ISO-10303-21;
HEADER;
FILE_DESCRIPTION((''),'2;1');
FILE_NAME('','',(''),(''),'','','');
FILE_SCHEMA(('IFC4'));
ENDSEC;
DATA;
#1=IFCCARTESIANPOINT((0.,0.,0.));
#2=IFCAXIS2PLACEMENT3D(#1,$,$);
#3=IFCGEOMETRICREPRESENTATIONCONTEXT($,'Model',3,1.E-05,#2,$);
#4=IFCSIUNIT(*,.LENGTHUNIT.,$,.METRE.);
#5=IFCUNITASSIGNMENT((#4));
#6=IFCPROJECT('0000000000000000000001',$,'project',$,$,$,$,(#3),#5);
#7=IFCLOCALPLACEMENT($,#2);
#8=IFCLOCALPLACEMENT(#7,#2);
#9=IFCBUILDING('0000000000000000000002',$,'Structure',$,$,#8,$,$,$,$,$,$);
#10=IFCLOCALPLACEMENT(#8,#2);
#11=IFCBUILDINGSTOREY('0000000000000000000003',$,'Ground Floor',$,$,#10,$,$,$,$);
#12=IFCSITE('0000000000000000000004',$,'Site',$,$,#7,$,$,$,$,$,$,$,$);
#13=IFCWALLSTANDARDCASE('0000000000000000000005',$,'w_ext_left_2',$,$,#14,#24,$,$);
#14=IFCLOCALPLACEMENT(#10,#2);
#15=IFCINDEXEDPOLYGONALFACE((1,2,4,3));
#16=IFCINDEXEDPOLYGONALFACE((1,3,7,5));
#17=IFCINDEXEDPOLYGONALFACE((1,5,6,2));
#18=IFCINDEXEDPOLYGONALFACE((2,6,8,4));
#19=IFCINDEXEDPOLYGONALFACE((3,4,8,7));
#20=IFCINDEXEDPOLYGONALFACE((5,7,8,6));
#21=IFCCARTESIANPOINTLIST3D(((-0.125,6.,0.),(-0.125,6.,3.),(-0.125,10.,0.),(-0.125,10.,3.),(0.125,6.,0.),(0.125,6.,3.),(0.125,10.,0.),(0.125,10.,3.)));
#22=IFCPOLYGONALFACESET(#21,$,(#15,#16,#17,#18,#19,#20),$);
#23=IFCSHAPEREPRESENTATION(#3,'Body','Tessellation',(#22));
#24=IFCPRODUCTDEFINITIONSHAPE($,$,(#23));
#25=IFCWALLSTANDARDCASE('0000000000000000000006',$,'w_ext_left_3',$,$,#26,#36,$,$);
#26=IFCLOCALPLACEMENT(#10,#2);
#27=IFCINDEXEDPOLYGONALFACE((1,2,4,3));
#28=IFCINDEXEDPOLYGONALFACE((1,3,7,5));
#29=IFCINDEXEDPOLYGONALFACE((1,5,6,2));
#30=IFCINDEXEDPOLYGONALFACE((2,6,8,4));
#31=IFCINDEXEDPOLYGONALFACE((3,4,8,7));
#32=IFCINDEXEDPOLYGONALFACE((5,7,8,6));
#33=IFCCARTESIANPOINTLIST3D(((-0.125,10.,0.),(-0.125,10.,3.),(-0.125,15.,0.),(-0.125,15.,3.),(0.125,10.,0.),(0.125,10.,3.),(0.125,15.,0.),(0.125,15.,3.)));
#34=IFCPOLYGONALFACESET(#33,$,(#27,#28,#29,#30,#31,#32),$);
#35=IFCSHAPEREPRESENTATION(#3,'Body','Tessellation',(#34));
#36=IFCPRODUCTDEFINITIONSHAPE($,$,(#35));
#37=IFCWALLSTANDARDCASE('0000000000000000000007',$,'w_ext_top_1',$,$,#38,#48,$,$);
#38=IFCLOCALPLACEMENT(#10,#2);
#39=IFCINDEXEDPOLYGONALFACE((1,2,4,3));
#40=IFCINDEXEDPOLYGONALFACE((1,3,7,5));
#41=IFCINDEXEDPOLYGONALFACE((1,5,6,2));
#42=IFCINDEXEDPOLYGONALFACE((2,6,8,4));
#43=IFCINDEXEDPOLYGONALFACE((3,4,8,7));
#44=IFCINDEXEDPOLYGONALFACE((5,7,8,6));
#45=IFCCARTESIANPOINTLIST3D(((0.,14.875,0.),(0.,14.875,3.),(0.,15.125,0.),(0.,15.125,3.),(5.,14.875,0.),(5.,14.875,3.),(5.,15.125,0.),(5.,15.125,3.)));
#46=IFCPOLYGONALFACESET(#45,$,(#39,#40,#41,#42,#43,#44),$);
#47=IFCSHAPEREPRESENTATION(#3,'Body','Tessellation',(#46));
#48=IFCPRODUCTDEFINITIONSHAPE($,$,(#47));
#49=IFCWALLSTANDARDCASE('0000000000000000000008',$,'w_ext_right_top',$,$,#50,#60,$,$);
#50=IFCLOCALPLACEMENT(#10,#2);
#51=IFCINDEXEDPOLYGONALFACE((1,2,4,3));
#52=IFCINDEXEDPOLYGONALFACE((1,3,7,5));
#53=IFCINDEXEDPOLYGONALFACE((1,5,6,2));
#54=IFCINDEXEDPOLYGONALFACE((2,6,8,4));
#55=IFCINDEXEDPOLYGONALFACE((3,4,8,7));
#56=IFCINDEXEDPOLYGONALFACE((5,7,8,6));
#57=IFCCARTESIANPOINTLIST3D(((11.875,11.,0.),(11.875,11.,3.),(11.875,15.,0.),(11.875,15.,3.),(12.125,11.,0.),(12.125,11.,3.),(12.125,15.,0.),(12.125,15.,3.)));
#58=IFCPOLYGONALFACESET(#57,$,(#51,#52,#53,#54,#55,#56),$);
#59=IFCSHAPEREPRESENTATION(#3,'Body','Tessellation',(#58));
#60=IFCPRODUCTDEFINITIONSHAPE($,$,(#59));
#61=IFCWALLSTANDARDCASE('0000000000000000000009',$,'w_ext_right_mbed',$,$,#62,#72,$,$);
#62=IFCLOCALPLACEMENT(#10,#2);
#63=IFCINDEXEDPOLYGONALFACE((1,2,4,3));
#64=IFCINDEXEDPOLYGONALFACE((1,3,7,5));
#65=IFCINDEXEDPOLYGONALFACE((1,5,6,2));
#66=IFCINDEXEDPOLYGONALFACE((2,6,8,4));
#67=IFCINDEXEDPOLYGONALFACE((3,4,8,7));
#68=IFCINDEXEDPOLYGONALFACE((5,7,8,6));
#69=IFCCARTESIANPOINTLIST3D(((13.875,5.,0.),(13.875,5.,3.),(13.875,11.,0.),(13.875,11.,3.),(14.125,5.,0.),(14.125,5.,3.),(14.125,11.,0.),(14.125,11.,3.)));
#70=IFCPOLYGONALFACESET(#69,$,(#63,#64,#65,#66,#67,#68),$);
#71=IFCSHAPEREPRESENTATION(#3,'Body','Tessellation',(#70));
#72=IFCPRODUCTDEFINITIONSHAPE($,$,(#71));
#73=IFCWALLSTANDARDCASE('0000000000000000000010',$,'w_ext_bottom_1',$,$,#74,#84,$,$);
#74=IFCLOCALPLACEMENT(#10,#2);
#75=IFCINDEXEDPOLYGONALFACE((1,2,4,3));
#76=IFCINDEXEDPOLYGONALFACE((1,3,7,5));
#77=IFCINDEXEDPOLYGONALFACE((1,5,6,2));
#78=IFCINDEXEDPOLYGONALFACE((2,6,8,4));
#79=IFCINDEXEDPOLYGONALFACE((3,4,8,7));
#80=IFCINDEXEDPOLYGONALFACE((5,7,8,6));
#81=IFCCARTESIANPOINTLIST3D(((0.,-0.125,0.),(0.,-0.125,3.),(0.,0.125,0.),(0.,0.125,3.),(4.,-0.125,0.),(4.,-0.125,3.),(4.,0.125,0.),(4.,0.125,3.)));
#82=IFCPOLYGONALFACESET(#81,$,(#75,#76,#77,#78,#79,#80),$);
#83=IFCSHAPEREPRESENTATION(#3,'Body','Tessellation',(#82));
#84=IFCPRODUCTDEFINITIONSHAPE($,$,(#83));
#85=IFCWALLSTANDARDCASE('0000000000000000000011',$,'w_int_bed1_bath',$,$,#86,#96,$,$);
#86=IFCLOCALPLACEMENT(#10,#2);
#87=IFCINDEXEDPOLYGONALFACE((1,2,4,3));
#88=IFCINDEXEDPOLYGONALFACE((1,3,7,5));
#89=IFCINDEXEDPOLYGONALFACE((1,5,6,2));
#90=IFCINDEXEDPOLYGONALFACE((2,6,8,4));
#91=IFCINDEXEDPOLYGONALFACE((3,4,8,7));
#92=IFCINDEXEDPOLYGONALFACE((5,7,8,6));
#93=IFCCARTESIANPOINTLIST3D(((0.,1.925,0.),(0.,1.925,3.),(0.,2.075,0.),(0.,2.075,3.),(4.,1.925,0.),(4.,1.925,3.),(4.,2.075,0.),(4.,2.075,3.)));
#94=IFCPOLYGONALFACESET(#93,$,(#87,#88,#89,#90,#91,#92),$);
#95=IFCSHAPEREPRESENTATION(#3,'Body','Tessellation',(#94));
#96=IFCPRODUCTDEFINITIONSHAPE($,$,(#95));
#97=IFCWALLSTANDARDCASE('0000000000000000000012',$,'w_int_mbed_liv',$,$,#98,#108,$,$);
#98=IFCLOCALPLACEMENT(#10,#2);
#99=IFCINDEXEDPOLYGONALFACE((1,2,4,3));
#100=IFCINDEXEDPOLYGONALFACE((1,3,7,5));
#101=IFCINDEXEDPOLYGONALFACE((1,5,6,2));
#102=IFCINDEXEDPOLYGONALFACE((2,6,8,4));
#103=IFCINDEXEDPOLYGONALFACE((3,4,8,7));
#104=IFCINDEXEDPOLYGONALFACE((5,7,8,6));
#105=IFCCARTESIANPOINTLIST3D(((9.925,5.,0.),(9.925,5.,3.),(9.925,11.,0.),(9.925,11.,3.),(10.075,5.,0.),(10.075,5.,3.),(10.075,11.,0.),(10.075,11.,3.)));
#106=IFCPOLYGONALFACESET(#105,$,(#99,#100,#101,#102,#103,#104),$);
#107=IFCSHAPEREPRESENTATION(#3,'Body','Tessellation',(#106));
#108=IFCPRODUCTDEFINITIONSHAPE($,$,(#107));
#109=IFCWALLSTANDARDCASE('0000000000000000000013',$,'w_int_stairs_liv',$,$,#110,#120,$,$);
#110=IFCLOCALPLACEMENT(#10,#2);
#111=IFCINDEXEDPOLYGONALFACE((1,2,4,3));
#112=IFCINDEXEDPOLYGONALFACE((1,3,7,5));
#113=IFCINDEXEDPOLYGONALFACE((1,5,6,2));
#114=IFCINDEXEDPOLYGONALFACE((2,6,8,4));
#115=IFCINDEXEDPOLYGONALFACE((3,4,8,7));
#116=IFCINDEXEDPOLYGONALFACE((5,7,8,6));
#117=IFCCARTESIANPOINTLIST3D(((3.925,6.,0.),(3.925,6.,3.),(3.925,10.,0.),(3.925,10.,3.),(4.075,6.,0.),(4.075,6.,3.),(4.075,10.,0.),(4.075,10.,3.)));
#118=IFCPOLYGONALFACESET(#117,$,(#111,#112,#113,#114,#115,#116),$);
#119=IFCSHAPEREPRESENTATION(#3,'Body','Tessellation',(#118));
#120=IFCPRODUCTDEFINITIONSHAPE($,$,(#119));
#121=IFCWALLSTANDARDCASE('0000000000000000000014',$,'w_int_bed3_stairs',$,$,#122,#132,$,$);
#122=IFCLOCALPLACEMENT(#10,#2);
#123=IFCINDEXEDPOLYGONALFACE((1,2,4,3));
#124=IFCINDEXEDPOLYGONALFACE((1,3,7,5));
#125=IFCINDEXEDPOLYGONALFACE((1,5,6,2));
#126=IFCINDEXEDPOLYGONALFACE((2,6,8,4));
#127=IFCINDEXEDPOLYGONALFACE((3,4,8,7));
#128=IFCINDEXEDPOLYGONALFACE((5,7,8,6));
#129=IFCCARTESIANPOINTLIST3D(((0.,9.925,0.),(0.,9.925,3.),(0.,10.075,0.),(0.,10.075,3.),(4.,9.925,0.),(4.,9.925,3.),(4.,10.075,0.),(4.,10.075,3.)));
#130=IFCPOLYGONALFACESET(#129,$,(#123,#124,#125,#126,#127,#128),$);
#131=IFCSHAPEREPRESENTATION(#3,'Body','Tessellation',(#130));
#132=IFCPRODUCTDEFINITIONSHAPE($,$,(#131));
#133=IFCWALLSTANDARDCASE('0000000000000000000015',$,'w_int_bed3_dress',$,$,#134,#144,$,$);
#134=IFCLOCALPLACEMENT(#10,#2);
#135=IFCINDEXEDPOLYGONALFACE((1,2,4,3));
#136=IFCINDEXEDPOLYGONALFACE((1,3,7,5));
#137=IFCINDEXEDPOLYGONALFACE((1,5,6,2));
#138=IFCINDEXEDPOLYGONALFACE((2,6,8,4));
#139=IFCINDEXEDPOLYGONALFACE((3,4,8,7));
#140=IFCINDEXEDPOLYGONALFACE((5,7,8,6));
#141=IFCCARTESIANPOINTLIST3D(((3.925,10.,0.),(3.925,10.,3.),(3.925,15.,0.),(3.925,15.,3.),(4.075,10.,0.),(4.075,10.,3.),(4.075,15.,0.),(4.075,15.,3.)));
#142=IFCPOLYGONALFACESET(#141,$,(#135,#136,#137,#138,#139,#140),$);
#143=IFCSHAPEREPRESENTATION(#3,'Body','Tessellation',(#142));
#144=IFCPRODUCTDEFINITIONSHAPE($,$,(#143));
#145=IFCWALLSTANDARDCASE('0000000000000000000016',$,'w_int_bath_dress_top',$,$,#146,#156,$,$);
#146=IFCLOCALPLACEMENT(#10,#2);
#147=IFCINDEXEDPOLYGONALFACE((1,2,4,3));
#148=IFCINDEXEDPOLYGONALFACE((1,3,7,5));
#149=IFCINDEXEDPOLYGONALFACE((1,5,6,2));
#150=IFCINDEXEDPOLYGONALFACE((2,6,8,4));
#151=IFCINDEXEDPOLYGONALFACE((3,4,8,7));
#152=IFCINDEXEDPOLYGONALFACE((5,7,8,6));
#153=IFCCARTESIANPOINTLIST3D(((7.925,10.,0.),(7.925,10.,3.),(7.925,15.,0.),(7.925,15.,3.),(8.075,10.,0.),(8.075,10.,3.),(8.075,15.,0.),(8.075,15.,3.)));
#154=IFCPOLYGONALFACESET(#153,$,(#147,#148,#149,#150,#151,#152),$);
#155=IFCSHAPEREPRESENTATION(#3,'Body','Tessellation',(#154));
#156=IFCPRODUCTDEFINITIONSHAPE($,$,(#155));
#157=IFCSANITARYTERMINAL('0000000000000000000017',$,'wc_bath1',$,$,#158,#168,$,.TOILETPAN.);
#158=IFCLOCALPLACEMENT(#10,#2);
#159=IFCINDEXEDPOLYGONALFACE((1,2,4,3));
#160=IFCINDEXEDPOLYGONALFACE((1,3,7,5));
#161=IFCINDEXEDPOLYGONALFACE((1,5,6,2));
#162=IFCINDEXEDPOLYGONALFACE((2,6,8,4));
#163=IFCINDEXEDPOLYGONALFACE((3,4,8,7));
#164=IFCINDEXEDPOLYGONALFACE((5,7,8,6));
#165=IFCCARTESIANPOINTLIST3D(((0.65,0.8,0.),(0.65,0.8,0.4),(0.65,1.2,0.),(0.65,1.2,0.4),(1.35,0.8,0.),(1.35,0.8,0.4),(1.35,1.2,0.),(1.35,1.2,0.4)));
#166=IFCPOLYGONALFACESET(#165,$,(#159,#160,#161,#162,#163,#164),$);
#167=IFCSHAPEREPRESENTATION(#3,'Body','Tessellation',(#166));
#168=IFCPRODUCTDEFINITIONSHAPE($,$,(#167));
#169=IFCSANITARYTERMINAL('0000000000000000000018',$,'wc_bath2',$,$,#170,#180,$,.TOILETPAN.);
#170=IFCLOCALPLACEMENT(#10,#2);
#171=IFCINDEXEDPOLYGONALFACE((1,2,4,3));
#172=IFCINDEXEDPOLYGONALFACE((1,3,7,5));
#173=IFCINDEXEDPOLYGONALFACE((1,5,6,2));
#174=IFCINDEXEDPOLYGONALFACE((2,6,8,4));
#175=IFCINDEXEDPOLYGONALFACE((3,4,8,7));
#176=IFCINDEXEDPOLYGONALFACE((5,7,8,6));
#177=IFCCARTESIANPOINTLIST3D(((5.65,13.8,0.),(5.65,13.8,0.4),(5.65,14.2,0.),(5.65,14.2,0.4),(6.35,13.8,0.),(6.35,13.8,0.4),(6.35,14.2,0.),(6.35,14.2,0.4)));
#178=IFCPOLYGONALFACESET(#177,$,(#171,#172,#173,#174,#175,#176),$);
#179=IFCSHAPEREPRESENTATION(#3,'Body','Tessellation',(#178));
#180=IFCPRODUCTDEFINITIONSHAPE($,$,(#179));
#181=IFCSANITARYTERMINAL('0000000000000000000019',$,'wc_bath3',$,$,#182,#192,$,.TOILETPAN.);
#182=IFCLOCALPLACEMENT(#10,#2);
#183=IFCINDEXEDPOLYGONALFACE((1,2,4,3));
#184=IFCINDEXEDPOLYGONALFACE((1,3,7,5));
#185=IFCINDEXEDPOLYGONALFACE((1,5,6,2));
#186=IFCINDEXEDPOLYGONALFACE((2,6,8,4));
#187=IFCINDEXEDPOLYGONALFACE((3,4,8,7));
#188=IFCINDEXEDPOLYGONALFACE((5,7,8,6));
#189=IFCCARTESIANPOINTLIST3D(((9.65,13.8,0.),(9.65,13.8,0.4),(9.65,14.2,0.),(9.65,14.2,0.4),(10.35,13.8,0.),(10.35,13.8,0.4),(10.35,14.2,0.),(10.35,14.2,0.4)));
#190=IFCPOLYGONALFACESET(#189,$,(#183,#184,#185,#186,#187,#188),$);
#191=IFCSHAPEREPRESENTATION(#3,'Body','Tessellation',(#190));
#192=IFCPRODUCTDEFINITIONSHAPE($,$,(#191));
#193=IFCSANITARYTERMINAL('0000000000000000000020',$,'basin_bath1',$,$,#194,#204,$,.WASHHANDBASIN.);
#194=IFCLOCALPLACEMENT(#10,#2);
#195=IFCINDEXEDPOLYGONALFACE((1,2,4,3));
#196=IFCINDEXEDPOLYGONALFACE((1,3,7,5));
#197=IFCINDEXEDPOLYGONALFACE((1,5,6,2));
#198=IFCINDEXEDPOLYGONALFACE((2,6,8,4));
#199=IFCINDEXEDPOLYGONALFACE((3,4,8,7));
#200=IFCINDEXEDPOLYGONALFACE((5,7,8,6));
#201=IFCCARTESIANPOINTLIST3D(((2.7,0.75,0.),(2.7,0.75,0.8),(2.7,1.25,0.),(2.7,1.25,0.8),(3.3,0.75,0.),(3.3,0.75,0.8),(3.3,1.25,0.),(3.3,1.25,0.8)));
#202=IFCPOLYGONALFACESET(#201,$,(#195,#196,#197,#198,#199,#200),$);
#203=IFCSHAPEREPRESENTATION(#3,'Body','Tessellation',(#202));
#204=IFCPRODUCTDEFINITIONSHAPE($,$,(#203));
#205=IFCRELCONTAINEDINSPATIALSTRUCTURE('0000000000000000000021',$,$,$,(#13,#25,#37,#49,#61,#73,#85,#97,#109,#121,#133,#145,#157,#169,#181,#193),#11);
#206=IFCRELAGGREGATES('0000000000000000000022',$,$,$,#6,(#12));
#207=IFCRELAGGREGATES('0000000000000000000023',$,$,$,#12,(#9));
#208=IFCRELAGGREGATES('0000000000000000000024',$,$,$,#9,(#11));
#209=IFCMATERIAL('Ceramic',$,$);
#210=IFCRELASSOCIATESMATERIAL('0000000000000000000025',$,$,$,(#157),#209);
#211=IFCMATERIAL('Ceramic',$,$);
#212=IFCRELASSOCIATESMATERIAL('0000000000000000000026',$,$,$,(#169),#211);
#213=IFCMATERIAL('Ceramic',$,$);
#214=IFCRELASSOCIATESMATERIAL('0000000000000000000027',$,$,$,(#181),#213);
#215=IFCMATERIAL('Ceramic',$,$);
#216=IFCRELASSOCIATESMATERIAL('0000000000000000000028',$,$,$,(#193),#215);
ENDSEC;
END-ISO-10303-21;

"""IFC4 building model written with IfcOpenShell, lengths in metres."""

from ifc_helpers import new_model, si_unit, frame, origin, place, context, project, spatial, polyline, outline, extrude, material, element, save


model = new_model("IFC4")

# Units and contexts
model_context = context("Model", 3, precision=1e-05, world=origin())
ifc_project = project(units=[si_unit("LENGTHUNIT", "METRE")], contexts=[model_context])

# Site, building, storey
site_placement = place(None, origin())
site = spatial("IfcSite", under=ifc_project, at=site_placement, Name="Site")
building_placement = place(site_placement, origin())
building = spatial("IfcBuilding", under=site, at=building_placement, Name="Structure")
storey_placement = place(building_placement, origin())
storey = spatial("IfcBuildingStorey", under=building, at=storey_placement, Name="Ground Floor")

# Walls
wall_1_placement = place(storey_placement, frame((0.0, 6.0, 0.0), x_axis=(0.0, 1.0, 0.0)))
element("IfcWallStandardCase", 1, at=wall_1_placement, inside=storey, Name="w_ext_left_2", context=model_context, shape_type="SweptSolid", body=[
    extrude(outline(polyline([(0.0, -0.125), (4.0, -0.125), (4.0, 0.125), (0.0, 0.125), (0.0, -0.125)])), origin(), (0.0, 0.0, 1.0), 3.0),
])
for number, where, x_axis, name in (
    (2, (0.0, 10.0, 0.0), (0.0, 1.0, 0.0), "w_ext_left_3"),
    (3, (0.0, 15.0, 0.0), (1.0, 0.0, 0.0), "w_ext_top_1"),
):
    element("IfcWallStandardCase", number, at=place(storey_placement, frame(where, x_axis=x_axis)), inside=storey, Name=name, context=model_context, shape_type="SweptSolid", body=[
        extrude(outline(polyline([(0.0, -0.125), (5.0, -0.125), (5.0, 0.125), (0.0, 0.125), (0.0, -0.125)])), origin(), (0.0, 0.0, 1.0), 3.0),
    ])
wall_2_placement = place(storey_placement, frame((12.0, 15.0, 0.0), x_axis=(0.0, -1.0, 0.0)))
element("IfcWallStandardCase", 4, at=wall_2_placement, inside=storey, Name="w_ext_right_top", context=model_context, shape_type="SweptSolid", body=[
    extrude(outline(polyline([(0.0, -0.125), (4.0, -0.125), (4.0, 0.125), (0.0, 0.125), (0.0, -0.125)])), origin(), (0.0, 0.0, 1.0), 3.0),
])
wall_3_placement = place(storey_placement, frame((14.0, 11.0, 0.0), x_axis=(0.0, -1.0, 0.0)))
element("IfcWallStandardCase", 5, at=wall_3_placement, inside=storey, Name="w_ext_right_mbed", context=model_context, shape_type="SweptSolid", body=[
    extrude(outline(polyline([(0.0, -0.125), (6.0, -0.125), (6.0, 0.125), (0.0, 0.125), (0.0, -0.125)])), origin(), (0.0, 0.0, 1.0), 3.0),
])
wall_4_placement = place(storey_placement, frame((0.0, 0.0, 0.0), x_axis=(1.0, 0.0, 0.0)))
element("IfcWallStandardCase", 6, at=wall_4_placement, inside=storey, Name="w_ext_bottom_1", context=model_context, shape_type="SweptSolid", body=[
    extrude(outline(polyline([(0.0, -0.125), (4.0, -0.125), (4.0, 0.125), (0.0, 0.125), (0.0, -0.125)])), origin(), (0.0, 0.0, 1.0), 3.0),
])
wall_5_placement = place(storey_placement, frame((0.0, 2.0, 0.0), x_axis=(1.0, 0.0, 0.0)))
element("IfcWallStandardCase", 7, at=wall_5_placement, inside=storey, Name="w_int_bed1_bath", context=model_context, shape_type="SweptSolid", body=[
    extrude(outline(polyline([(0.0, -0.075), (4.0, -0.075), (4.0, 0.075), (0.0, 0.075), (0.0, -0.075)])), origin(), (0.0, 0.0, 1.0), 3.0),
])
wall_6_placement = place(storey_placement, frame((10.0, 5.0, 0.0), x_axis=(0.0, 1.0, 0.0)))
element("IfcWallStandardCase", 8, at=wall_6_placement, inside=storey, Name="w_int_mbed_liv", context=model_context, shape_type="SweptSolid", body=[
    extrude(outline(polyline([(0.0, -0.075), (6.0, -0.075), (6.0, 0.075), (0.0, 0.075), (0.0, -0.075)])), origin(), (0.0, 0.0, 1.0), 3.0),
])
for number, where, x_axis, name in (
    (9, (4.0, 6.0, 0.0), (0.0, 1.0, 0.0), "w_int_stairs_liv"),
    (10, (0.0, 10.0, 0.0), (1.0, 0.0, 0.0), "w_int_bed3_stairs"),
):
    element("IfcWallStandardCase", number, at=place(storey_placement, frame(where, x_axis=x_axis)), inside=storey, Name=name, context=model_context, shape_type="SweptSolid", body=[
        extrude(outline(polyline([(0.0, -0.075), (4.0, -0.075), (4.0, 0.075), (0.0, 0.075), (0.0, -0.075)])), origin(), (0.0, 0.0, 1.0), 3.0),
    ])
for number, where, x_axis, name in (
    (11, (4.0, 10.0, 0.0), (0.0, 1.0, 0.0), "w_int_bed3_dress"),
    (12, (8.0, 10.0, 0.0), (0.0, 1.0, 0.0), "w_int_bath_dress_top"),
):
    element("IfcWallStandardCase", number, at=place(storey_placement, frame(where, x_axis=x_axis)), inside=storey, Name=name, context=model_context, shape_type="SweptSolid", body=[
        extrude(outline(polyline([(0.0, -0.075), (5.0, -0.075), (5.0, 0.075), (0.0, 0.075), (0.0, -0.075)])), origin(), (0.0, 0.0, 1.0), 3.0),
    ])

# Sanitary terminals
ifc_material_1 = material(Name="Ceramic")
sanitary_terminal_1_placement = place(storey_placement, frame((1.0, 1.0, 0.0)))
element("IfcSanitaryTerminal", 13, at=sanitary_terminal_1_placement, inside=storey, material=ifc_material_1, Name="wc_bath1", PredefinedType="TOILETPAN", context=model_context, shape_type="SweptSolid", body=[
    extrude(outline(polyline([(-0.35, -0.2), (0.35, -0.2), (0.35, 0.2), (-0.35, 0.2), (-0.35, -0.2)])), origin(), (0.0, 0.0, 1.0), 0.4),
])
ifc_material_2 = material(Name="Ceramic")
sanitary_terminal_2_placement = place(storey_placement, frame((6.0, 14.0, 0.0)))
element("IfcSanitaryTerminal", 14, at=sanitary_terminal_2_placement, inside=storey, material=ifc_material_2, Name="wc_bath2", PredefinedType="TOILETPAN", context=model_context, shape_type="SweptSolid", body=[
    extrude(outline(polyline([(-0.35, -0.2), (0.35, -0.2), (0.35, 0.2), (-0.35, 0.2), (-0.35, -0.2)])), origin(), (0.0, 0.0, 1.0), 0.4),
])
ifc_material_3 = material(Name="Ceramic")
sanitary_terminal_3_placement = place(storey_placement, frame((10.0, 14.0, 0.0)))
element("IfcSanitaryTerminal", 15, at=sanitary_terminal_3_placement, inside=storey, material=ifc_material_3, Name="wc_bath3", PredefinedType="TOILETPAN", context=model_context, shape_type="SweptSolid", body=[
    extrude(outline(polyline([(-0.35, -0.2), (0.35, -0.2), (0.35, 0.2), (-0.35, 0.2), (-0.35, -0.2)])), origin(), (0.0, 0.0, 1.0), 0.4),
])
ifc_material_4 = material(Name="Ceramic")
sanitary_terminal_4_placement = place(storey_placement, frame((3.0, 1.0, 0.0)))
element("IfcSanitaryTerminal", 16, at=sanitary_terminal_4_placement, inside=storey, material=ifc_material_4, Name="basin_bath1", PredefinedType="WASHHANDBASIN", context=model_context, shape_type="SweptSolid", body=[
    extrude(outline(polyline([(-0.3, -0.25), (0.3, -0.25), (0.3, 0.25), (-0.3, 0.25), (-0.3, -0.25)])), origin(), (0.0, 0.0, 1.0), 0.8),
])

save(model, "model.ifc")
